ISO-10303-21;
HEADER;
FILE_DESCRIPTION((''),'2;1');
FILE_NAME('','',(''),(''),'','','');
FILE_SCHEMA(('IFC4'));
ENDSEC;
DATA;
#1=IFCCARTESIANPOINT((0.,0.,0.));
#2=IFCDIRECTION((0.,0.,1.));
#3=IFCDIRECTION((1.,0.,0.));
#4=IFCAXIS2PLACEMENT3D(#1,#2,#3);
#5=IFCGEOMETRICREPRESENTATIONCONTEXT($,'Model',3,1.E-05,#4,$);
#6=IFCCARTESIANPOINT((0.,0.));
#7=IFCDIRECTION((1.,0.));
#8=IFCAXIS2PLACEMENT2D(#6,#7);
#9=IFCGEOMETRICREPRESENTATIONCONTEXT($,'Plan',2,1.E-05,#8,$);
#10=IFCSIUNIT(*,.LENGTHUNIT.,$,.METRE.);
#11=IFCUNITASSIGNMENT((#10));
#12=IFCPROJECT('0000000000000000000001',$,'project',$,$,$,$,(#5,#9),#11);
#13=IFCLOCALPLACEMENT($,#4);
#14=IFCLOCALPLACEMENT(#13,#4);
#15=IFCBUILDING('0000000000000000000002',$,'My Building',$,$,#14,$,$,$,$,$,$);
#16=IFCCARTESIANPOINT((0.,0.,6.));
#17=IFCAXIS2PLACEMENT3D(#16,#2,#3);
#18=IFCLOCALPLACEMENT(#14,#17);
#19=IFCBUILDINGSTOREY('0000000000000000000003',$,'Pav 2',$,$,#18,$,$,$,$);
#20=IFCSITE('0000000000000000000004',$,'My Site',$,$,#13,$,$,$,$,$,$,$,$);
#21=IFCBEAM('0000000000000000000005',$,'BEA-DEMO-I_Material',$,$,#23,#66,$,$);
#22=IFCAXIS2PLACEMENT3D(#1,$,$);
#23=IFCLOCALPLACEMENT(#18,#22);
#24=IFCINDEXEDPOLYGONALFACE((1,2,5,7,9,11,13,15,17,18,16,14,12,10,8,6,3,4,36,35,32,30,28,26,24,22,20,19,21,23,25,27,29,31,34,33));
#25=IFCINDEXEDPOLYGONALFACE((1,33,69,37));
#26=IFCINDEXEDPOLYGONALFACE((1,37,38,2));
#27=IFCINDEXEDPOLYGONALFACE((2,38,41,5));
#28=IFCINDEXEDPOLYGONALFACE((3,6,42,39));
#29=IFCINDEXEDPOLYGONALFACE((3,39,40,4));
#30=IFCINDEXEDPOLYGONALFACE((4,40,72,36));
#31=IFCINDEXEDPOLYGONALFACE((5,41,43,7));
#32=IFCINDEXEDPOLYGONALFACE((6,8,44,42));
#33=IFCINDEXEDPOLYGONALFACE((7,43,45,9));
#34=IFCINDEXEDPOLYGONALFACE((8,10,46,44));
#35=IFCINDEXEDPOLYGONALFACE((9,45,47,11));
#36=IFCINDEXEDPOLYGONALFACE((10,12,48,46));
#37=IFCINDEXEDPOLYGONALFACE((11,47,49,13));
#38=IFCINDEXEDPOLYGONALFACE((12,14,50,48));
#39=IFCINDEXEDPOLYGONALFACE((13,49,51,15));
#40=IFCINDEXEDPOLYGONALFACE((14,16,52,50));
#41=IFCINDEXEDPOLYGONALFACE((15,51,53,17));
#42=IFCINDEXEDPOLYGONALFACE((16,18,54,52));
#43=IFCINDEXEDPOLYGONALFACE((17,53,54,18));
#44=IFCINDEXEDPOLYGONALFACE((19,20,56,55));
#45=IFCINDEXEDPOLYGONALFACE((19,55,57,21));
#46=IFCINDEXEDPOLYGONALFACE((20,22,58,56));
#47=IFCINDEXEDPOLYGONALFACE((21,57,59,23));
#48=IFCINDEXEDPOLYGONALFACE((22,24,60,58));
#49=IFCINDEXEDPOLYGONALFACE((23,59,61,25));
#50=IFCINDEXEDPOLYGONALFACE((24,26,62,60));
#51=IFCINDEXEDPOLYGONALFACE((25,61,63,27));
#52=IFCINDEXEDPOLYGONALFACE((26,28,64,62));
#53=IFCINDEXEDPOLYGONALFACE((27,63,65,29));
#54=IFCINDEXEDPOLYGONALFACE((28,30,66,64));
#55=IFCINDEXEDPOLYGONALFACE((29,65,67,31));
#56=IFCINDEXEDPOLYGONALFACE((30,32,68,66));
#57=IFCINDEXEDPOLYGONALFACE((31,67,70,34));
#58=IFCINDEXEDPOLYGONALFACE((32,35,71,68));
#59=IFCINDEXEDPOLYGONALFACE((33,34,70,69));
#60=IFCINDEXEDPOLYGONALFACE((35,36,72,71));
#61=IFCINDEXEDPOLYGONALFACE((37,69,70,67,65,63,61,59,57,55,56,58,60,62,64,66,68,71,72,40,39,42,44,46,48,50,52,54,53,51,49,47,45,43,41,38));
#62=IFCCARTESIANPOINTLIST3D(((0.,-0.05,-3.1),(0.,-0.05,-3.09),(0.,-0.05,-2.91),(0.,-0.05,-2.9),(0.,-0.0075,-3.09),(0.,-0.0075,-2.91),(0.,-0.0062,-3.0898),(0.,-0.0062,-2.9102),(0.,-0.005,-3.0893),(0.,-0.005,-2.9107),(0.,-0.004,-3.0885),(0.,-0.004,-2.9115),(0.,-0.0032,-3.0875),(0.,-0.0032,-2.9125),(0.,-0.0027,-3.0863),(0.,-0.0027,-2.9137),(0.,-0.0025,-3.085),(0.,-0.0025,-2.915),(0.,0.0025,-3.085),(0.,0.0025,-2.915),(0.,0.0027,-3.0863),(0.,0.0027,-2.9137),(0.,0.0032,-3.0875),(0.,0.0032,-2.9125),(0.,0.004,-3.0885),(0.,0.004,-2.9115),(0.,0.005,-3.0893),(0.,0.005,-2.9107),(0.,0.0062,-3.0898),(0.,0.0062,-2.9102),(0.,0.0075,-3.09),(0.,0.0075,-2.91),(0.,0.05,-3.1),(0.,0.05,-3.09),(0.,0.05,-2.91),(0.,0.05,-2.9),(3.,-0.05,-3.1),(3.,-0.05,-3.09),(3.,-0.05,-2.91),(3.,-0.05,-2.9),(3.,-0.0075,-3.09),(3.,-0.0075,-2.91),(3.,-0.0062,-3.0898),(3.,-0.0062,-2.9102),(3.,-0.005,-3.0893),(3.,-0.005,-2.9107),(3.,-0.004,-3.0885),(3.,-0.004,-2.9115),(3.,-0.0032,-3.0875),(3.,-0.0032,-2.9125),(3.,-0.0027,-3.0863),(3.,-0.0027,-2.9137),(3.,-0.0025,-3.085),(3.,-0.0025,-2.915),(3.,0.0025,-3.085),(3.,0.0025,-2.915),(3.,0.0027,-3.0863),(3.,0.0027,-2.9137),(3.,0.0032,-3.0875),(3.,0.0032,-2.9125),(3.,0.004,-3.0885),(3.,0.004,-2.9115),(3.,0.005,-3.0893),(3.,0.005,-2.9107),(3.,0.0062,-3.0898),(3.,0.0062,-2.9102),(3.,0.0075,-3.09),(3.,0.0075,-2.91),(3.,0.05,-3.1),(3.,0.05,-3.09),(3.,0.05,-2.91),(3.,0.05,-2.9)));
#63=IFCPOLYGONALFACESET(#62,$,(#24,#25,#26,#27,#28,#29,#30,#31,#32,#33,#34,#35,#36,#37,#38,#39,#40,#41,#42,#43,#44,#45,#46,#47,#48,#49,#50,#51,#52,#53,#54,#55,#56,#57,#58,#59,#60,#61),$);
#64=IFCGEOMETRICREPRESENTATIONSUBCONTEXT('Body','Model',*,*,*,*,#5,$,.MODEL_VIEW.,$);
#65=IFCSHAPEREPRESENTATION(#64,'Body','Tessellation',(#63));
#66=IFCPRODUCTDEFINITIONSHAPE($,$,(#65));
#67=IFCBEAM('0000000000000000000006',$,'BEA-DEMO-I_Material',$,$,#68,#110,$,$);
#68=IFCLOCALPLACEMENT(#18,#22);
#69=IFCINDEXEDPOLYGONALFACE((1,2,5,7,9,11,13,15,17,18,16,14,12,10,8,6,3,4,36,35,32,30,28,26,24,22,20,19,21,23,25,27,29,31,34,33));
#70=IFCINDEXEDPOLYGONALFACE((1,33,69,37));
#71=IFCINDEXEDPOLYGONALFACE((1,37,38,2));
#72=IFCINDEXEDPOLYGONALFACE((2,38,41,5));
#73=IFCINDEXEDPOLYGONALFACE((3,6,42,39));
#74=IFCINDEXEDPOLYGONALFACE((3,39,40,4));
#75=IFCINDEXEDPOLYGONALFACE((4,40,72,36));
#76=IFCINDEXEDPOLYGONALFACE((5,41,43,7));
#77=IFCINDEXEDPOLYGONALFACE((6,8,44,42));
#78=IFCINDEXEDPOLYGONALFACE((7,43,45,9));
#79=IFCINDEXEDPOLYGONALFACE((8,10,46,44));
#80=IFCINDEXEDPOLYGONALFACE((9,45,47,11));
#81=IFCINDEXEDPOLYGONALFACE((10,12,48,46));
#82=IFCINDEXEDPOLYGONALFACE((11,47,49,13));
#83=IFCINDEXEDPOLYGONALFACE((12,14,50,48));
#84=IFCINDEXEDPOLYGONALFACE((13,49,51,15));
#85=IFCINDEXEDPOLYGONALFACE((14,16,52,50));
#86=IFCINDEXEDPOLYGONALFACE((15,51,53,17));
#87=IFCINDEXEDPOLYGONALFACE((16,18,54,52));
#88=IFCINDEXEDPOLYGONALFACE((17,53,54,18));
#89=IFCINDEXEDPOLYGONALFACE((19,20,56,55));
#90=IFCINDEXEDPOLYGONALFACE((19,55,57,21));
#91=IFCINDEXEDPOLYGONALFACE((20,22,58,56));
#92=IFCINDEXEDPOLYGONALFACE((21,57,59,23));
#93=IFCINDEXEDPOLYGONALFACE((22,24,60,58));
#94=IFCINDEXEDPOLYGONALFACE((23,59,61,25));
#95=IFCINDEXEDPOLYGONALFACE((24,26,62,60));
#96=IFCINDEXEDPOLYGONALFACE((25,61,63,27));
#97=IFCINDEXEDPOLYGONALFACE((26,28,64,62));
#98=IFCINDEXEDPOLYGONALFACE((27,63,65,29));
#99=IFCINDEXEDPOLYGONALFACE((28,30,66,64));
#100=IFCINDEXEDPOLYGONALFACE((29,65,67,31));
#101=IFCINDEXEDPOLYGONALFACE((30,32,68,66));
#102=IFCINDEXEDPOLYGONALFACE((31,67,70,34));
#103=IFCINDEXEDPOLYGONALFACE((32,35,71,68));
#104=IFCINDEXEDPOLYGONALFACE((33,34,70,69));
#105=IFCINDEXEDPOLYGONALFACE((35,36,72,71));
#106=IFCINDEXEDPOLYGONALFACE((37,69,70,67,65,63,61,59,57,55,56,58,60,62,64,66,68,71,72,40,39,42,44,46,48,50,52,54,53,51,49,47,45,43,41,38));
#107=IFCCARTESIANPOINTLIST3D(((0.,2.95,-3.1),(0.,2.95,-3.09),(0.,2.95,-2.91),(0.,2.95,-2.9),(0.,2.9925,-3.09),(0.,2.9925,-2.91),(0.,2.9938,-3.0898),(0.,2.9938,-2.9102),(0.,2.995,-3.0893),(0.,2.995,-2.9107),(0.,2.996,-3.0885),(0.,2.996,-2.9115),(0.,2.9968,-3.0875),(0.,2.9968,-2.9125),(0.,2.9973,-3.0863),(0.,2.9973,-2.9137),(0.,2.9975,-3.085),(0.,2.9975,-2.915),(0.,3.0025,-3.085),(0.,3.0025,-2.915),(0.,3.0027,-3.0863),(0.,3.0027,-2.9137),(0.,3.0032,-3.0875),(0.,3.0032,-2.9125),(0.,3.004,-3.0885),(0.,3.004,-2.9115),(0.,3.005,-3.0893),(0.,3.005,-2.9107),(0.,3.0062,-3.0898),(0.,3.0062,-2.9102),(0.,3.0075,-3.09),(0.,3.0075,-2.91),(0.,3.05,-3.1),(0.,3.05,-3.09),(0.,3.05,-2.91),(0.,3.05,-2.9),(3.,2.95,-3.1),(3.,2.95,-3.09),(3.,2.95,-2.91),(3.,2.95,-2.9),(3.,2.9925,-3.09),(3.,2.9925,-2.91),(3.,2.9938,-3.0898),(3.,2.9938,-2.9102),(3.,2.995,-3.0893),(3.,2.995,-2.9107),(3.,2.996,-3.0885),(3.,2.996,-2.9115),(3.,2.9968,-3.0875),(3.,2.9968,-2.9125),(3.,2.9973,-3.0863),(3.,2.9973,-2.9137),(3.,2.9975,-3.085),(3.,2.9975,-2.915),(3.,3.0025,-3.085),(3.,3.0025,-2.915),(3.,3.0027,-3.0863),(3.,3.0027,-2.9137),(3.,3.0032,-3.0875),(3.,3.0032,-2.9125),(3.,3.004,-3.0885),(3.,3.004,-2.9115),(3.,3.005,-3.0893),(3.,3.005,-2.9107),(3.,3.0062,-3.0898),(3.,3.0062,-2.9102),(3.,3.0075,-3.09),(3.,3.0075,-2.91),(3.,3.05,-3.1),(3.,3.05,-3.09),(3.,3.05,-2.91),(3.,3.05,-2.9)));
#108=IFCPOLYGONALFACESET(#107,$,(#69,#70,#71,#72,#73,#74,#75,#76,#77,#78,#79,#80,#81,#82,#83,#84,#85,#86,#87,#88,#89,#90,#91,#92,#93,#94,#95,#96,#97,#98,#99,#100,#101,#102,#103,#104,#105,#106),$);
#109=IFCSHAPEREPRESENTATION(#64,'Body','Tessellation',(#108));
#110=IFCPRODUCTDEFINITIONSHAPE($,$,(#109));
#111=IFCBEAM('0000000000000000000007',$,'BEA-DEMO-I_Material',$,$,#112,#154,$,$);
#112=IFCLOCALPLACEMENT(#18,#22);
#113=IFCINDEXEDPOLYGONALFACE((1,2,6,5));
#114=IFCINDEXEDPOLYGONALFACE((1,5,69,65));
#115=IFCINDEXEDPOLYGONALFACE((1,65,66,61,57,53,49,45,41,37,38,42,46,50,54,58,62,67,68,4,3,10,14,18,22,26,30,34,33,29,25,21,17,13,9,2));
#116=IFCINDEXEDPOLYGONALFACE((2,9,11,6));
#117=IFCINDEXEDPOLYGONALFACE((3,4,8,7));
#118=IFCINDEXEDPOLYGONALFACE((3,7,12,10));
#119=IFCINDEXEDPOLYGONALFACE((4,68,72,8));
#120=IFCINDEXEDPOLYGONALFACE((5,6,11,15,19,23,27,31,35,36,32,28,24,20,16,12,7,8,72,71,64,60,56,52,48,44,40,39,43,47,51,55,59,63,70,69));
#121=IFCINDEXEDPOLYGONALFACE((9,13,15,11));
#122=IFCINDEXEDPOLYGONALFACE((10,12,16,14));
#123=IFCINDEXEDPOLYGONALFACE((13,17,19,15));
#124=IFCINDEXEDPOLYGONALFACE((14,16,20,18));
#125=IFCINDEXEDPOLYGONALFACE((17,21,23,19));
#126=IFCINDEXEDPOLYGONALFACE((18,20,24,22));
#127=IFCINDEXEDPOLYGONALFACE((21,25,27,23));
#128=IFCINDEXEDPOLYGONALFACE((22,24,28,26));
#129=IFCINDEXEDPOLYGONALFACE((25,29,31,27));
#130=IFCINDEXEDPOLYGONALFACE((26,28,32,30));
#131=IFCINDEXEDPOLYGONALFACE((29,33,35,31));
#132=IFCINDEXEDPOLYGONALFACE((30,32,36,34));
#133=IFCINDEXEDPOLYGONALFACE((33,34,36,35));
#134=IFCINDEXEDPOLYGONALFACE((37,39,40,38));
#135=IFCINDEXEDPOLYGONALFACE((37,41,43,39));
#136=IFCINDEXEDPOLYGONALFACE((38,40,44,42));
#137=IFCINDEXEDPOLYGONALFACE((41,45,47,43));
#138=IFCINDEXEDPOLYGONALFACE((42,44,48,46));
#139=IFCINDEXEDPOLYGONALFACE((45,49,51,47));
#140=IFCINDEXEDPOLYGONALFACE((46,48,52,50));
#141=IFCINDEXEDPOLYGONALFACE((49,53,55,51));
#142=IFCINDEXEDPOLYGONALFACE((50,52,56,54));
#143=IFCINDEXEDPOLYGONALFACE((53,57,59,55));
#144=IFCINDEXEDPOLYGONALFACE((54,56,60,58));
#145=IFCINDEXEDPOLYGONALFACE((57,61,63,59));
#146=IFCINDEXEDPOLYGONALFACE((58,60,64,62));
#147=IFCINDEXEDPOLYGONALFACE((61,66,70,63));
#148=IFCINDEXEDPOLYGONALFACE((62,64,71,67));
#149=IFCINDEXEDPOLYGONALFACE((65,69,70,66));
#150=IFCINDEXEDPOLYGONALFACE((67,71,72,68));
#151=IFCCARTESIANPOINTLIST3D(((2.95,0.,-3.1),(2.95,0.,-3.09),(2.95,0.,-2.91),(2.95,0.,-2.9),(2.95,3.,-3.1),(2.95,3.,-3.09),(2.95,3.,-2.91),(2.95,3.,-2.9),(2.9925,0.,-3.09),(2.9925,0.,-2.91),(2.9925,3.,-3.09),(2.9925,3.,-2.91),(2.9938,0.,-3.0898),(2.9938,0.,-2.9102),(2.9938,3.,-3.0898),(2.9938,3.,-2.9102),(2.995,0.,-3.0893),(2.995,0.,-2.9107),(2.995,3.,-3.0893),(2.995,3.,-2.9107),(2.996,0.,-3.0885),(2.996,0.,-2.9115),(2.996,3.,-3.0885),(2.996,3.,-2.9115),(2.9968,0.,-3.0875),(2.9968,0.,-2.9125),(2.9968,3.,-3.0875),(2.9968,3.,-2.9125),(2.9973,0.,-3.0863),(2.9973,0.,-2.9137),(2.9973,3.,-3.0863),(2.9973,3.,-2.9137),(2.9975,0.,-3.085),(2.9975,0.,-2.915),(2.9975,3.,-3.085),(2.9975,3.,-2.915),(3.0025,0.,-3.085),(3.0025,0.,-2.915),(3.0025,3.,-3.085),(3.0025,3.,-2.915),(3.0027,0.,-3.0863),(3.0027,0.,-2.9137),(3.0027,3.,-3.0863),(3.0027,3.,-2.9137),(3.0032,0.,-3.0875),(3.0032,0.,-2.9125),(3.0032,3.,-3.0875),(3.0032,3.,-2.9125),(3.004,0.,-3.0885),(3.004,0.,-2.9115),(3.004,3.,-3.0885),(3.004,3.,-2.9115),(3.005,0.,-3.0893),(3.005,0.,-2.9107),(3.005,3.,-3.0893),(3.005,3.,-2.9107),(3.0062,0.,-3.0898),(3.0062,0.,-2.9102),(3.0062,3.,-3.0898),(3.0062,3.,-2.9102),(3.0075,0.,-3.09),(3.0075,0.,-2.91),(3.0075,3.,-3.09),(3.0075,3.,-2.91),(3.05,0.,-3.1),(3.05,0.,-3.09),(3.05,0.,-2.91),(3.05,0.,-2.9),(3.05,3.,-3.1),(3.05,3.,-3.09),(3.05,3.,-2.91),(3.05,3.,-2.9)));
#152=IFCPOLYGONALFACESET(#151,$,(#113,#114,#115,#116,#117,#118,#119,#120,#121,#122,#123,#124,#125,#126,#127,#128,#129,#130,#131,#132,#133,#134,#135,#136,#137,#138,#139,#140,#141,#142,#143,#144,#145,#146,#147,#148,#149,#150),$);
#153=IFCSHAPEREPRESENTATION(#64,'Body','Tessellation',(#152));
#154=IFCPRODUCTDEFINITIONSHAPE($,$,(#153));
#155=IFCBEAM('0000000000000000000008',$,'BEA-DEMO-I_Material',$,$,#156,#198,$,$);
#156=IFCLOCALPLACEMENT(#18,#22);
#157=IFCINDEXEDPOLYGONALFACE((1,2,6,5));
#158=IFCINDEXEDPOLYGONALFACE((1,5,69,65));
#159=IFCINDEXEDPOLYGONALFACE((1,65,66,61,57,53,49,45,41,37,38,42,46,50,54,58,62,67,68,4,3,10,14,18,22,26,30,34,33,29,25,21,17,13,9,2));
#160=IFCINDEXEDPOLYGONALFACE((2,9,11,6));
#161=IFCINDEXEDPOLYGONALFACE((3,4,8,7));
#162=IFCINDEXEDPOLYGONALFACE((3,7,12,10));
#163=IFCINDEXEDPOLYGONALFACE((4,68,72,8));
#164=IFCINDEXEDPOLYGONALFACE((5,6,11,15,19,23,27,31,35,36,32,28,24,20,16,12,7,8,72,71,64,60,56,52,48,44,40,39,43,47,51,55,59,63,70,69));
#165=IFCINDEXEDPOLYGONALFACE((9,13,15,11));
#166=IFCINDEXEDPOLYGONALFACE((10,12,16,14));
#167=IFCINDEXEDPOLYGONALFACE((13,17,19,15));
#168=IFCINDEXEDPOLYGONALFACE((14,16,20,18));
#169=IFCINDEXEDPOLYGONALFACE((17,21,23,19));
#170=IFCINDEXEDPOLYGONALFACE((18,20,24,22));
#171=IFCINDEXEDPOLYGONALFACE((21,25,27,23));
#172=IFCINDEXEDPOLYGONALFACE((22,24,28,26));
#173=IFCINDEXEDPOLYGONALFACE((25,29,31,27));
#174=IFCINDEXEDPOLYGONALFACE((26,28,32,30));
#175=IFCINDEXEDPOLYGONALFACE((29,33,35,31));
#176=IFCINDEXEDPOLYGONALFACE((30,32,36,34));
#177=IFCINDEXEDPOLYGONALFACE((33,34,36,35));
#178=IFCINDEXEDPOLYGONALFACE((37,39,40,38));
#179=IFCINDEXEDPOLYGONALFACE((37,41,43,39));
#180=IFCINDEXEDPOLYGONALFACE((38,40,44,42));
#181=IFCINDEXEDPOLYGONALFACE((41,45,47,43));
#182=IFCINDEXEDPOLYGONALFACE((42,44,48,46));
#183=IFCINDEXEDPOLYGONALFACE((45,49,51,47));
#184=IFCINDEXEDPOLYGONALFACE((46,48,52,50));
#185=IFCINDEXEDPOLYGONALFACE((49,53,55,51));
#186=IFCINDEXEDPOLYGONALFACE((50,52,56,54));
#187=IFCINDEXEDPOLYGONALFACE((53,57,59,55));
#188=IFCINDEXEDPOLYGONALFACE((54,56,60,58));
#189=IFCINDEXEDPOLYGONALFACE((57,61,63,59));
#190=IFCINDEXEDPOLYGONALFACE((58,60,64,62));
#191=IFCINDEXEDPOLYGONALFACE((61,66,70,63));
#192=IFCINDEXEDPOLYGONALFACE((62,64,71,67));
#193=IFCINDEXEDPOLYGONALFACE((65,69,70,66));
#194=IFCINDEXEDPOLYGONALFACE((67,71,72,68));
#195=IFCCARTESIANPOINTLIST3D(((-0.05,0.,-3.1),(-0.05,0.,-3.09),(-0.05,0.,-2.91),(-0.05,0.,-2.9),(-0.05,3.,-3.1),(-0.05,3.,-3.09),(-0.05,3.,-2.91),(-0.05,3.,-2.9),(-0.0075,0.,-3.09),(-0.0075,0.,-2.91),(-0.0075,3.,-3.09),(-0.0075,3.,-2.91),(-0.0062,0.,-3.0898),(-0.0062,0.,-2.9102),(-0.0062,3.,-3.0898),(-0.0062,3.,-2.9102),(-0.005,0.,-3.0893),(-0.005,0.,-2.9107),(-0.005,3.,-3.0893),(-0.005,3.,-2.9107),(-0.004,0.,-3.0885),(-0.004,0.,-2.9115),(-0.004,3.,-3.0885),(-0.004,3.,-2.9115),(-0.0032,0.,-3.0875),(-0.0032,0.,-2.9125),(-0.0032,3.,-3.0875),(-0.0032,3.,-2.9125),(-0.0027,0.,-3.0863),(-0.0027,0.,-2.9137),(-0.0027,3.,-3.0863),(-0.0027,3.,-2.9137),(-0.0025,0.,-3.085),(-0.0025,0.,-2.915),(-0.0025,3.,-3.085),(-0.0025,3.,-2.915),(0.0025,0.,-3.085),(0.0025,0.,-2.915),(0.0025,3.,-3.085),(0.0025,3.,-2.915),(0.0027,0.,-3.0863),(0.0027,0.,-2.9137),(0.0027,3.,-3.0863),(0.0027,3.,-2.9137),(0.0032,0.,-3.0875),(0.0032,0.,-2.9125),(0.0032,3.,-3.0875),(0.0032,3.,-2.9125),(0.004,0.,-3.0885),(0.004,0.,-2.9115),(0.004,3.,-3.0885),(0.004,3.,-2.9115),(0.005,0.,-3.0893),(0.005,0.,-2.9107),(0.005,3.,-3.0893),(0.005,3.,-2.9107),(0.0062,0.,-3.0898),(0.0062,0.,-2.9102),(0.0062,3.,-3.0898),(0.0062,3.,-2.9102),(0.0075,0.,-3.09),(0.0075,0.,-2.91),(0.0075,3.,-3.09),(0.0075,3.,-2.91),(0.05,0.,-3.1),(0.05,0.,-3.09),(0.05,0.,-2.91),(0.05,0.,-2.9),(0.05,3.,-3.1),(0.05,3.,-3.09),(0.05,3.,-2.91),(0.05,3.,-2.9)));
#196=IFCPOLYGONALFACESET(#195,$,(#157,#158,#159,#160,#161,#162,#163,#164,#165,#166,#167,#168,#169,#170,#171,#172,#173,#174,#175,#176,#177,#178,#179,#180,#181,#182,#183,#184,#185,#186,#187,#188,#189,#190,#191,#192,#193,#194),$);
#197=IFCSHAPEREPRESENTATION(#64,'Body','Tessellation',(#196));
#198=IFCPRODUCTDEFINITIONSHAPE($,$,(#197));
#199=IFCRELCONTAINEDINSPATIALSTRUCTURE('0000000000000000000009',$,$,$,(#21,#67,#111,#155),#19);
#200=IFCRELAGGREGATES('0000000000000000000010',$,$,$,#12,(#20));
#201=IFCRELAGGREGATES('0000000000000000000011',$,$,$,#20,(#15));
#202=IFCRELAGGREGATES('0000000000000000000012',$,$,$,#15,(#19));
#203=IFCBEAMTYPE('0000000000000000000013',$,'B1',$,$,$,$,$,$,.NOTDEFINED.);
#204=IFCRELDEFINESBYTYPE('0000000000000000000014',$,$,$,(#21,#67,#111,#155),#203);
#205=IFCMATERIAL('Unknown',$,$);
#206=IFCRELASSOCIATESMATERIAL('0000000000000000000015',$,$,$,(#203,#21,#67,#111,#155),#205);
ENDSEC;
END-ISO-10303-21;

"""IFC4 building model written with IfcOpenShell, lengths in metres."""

from ifc_helpers import new_model, si_unit, frame, origin, origin_with_axes, origin_2d_with_axis, place, context, subcontext, project, spatial, i_section, extrude, material, material_profile, profile_set, profile_usage, type_object, element, save


model = new_model("IFC4")

# Units and contexts
model_context = context("Model", 3, precision=1e-05, world=origin_with_axes())
plan_context = context("Plan", 2, precision=1e-05, world=origin_2d_with_axis())
body_context = subcontext(model_context, "Body", "Model", "MODEL_VIEW")
ifc_project = project(units=[si_unit("LENGTHUNIT", "METRE")], contexts=[model_context, plan_context])

# Site, building, storey
site_placement = place(None, origin_with_axes())
site = spatial("IfcSite", under=ifc_project, at=site_placement, Name="My Site")
building_placement = place(site_placement, origin_with_axes())
building = spatial("IfcBuilding", under=site, at=building_placement, Name="My Building")
storey_placement = place(building_placement, frame((0.0, 0.0, 6.0), z_axis=(0.0, 0.0, 1.0), x_axis=(1.0, 0.0, 0.0)))
storey = spatial("IfcBuildingStorey", under=building, at=storey_placement, Name="Pav 2")

# Beams
ifc_material = material(Name="Unknown")
ifc_material_profile = material_profile(ifc_material, i_section(OverallWidth=0.1, OverallDepth=0.2, WebThickness=0.005, FlangeThickness=0.01, FilletRadius=0.005))
ifc_profile_set = profile_set([ifc_material_profile])
ifc_profile_usage_1 = profile_usage(ifc_profile_set, cardinal=5)
beam_type = type_object("IfcBeamType", Name="B1", PredefinedType="NOTDEFINED", material=ifc_profile_set)
beam_1_placement = place(storey_placement, frame((3.0, 0.0, -3.0), z_axis=(-1.0, 0.0, 0.0), x_axis=(0.0, -1.0, 0.0)))
element("IfcBeam", 1, at=beam_1_placement, inside=storey, type_object=beam_type, material=ifc_profile_usage_1, Name="BEA-DEMO-I_Material", context=body_context, shape_type="SweptSolid", body=[
    extrude(i_section(OverallWidth=0.1, OverallDepth=0.2, WebThickness=0.005, FlangeThickness=0.01, FilletRadius=0.005), origin(), (0.0, 0.0, 1.0), 3.0),
])
ifc_profile_usage_2 = profile_usage(ifc_profile_set, cardinal=5)
beam_2_placement = place(storey_placement, frame((0.0, 3.0, -3.0), z_axis=(1.0, 0.0, 0.0), x_axis=(0.0, 1.0, 0.0)))
element("IfcBeam", 2, at=beam_2_placement, inside=storey, type_object=beam_type, material=ifc_profile_usage_2, Name="BEA-DEMO-I_Material", context=body_context, shape_type="SweptSolid", body=[
    extrude(i_section(OverallWidth=0.1, OverallDepth=0.2, WebThickness=0.005, FlangeThickness=0.01, FilletRadius=0.005), origin(), (0.0, 0.0, 1.0), 3.0),
])
ifc_profile_usage_3 = profile_usage(ifc_profile_set, cardinal=5)
beam_3_placement = place(storey_placement, frame((3.0, 3.0, -3.0), z_axis=(0.0, -1.0, 0.0), x_axis=(1.0, 0.0, 0.0)))
element("IfcBeam", 3, at=beam_3_placement, inside=storey, type_object=beam_type, material=ifc_profile_usage_3, Name="BEA-DEMO-I_Material", context=body_context, shape_type="SweptSolid", body=[
    extrude(i_section(OverallWidth=0.1, OverallDepth=0.2, WebThickness=0.005, FlangeThickness=0.01, FilletRadius=0.005), origin(), (0.0, 0.0, 1.0), 3.0),
])
ifc_profile_usage_4 = profile_usage(ifc_profile_set, cardinal=5)
beam_4_placement = place(storey_placement, frame((0.0, 0.0, -3.0), z_axis=(0.0, 1.0, 0.0), x_axis=(-1.0, 0.0, 0.0)))
element("IfcBeam", 4, at=beam_4_placement, inside=storey, type_object=beam_type, material=ifc_profile_usage_4, Name="BEA-DEMO-I_Material", context=body_context, shape_type="SweptSolid", body=[
    extrude(i_section(OverallWidth=0.1, OverallDepth=0.2, WebThickness=0.005, FlangeThickness=0.01, FilletRadius=0.005), origin(), (0.0, 0.0, 1.0), 3.0),
])

save(model, "model.ifc")
